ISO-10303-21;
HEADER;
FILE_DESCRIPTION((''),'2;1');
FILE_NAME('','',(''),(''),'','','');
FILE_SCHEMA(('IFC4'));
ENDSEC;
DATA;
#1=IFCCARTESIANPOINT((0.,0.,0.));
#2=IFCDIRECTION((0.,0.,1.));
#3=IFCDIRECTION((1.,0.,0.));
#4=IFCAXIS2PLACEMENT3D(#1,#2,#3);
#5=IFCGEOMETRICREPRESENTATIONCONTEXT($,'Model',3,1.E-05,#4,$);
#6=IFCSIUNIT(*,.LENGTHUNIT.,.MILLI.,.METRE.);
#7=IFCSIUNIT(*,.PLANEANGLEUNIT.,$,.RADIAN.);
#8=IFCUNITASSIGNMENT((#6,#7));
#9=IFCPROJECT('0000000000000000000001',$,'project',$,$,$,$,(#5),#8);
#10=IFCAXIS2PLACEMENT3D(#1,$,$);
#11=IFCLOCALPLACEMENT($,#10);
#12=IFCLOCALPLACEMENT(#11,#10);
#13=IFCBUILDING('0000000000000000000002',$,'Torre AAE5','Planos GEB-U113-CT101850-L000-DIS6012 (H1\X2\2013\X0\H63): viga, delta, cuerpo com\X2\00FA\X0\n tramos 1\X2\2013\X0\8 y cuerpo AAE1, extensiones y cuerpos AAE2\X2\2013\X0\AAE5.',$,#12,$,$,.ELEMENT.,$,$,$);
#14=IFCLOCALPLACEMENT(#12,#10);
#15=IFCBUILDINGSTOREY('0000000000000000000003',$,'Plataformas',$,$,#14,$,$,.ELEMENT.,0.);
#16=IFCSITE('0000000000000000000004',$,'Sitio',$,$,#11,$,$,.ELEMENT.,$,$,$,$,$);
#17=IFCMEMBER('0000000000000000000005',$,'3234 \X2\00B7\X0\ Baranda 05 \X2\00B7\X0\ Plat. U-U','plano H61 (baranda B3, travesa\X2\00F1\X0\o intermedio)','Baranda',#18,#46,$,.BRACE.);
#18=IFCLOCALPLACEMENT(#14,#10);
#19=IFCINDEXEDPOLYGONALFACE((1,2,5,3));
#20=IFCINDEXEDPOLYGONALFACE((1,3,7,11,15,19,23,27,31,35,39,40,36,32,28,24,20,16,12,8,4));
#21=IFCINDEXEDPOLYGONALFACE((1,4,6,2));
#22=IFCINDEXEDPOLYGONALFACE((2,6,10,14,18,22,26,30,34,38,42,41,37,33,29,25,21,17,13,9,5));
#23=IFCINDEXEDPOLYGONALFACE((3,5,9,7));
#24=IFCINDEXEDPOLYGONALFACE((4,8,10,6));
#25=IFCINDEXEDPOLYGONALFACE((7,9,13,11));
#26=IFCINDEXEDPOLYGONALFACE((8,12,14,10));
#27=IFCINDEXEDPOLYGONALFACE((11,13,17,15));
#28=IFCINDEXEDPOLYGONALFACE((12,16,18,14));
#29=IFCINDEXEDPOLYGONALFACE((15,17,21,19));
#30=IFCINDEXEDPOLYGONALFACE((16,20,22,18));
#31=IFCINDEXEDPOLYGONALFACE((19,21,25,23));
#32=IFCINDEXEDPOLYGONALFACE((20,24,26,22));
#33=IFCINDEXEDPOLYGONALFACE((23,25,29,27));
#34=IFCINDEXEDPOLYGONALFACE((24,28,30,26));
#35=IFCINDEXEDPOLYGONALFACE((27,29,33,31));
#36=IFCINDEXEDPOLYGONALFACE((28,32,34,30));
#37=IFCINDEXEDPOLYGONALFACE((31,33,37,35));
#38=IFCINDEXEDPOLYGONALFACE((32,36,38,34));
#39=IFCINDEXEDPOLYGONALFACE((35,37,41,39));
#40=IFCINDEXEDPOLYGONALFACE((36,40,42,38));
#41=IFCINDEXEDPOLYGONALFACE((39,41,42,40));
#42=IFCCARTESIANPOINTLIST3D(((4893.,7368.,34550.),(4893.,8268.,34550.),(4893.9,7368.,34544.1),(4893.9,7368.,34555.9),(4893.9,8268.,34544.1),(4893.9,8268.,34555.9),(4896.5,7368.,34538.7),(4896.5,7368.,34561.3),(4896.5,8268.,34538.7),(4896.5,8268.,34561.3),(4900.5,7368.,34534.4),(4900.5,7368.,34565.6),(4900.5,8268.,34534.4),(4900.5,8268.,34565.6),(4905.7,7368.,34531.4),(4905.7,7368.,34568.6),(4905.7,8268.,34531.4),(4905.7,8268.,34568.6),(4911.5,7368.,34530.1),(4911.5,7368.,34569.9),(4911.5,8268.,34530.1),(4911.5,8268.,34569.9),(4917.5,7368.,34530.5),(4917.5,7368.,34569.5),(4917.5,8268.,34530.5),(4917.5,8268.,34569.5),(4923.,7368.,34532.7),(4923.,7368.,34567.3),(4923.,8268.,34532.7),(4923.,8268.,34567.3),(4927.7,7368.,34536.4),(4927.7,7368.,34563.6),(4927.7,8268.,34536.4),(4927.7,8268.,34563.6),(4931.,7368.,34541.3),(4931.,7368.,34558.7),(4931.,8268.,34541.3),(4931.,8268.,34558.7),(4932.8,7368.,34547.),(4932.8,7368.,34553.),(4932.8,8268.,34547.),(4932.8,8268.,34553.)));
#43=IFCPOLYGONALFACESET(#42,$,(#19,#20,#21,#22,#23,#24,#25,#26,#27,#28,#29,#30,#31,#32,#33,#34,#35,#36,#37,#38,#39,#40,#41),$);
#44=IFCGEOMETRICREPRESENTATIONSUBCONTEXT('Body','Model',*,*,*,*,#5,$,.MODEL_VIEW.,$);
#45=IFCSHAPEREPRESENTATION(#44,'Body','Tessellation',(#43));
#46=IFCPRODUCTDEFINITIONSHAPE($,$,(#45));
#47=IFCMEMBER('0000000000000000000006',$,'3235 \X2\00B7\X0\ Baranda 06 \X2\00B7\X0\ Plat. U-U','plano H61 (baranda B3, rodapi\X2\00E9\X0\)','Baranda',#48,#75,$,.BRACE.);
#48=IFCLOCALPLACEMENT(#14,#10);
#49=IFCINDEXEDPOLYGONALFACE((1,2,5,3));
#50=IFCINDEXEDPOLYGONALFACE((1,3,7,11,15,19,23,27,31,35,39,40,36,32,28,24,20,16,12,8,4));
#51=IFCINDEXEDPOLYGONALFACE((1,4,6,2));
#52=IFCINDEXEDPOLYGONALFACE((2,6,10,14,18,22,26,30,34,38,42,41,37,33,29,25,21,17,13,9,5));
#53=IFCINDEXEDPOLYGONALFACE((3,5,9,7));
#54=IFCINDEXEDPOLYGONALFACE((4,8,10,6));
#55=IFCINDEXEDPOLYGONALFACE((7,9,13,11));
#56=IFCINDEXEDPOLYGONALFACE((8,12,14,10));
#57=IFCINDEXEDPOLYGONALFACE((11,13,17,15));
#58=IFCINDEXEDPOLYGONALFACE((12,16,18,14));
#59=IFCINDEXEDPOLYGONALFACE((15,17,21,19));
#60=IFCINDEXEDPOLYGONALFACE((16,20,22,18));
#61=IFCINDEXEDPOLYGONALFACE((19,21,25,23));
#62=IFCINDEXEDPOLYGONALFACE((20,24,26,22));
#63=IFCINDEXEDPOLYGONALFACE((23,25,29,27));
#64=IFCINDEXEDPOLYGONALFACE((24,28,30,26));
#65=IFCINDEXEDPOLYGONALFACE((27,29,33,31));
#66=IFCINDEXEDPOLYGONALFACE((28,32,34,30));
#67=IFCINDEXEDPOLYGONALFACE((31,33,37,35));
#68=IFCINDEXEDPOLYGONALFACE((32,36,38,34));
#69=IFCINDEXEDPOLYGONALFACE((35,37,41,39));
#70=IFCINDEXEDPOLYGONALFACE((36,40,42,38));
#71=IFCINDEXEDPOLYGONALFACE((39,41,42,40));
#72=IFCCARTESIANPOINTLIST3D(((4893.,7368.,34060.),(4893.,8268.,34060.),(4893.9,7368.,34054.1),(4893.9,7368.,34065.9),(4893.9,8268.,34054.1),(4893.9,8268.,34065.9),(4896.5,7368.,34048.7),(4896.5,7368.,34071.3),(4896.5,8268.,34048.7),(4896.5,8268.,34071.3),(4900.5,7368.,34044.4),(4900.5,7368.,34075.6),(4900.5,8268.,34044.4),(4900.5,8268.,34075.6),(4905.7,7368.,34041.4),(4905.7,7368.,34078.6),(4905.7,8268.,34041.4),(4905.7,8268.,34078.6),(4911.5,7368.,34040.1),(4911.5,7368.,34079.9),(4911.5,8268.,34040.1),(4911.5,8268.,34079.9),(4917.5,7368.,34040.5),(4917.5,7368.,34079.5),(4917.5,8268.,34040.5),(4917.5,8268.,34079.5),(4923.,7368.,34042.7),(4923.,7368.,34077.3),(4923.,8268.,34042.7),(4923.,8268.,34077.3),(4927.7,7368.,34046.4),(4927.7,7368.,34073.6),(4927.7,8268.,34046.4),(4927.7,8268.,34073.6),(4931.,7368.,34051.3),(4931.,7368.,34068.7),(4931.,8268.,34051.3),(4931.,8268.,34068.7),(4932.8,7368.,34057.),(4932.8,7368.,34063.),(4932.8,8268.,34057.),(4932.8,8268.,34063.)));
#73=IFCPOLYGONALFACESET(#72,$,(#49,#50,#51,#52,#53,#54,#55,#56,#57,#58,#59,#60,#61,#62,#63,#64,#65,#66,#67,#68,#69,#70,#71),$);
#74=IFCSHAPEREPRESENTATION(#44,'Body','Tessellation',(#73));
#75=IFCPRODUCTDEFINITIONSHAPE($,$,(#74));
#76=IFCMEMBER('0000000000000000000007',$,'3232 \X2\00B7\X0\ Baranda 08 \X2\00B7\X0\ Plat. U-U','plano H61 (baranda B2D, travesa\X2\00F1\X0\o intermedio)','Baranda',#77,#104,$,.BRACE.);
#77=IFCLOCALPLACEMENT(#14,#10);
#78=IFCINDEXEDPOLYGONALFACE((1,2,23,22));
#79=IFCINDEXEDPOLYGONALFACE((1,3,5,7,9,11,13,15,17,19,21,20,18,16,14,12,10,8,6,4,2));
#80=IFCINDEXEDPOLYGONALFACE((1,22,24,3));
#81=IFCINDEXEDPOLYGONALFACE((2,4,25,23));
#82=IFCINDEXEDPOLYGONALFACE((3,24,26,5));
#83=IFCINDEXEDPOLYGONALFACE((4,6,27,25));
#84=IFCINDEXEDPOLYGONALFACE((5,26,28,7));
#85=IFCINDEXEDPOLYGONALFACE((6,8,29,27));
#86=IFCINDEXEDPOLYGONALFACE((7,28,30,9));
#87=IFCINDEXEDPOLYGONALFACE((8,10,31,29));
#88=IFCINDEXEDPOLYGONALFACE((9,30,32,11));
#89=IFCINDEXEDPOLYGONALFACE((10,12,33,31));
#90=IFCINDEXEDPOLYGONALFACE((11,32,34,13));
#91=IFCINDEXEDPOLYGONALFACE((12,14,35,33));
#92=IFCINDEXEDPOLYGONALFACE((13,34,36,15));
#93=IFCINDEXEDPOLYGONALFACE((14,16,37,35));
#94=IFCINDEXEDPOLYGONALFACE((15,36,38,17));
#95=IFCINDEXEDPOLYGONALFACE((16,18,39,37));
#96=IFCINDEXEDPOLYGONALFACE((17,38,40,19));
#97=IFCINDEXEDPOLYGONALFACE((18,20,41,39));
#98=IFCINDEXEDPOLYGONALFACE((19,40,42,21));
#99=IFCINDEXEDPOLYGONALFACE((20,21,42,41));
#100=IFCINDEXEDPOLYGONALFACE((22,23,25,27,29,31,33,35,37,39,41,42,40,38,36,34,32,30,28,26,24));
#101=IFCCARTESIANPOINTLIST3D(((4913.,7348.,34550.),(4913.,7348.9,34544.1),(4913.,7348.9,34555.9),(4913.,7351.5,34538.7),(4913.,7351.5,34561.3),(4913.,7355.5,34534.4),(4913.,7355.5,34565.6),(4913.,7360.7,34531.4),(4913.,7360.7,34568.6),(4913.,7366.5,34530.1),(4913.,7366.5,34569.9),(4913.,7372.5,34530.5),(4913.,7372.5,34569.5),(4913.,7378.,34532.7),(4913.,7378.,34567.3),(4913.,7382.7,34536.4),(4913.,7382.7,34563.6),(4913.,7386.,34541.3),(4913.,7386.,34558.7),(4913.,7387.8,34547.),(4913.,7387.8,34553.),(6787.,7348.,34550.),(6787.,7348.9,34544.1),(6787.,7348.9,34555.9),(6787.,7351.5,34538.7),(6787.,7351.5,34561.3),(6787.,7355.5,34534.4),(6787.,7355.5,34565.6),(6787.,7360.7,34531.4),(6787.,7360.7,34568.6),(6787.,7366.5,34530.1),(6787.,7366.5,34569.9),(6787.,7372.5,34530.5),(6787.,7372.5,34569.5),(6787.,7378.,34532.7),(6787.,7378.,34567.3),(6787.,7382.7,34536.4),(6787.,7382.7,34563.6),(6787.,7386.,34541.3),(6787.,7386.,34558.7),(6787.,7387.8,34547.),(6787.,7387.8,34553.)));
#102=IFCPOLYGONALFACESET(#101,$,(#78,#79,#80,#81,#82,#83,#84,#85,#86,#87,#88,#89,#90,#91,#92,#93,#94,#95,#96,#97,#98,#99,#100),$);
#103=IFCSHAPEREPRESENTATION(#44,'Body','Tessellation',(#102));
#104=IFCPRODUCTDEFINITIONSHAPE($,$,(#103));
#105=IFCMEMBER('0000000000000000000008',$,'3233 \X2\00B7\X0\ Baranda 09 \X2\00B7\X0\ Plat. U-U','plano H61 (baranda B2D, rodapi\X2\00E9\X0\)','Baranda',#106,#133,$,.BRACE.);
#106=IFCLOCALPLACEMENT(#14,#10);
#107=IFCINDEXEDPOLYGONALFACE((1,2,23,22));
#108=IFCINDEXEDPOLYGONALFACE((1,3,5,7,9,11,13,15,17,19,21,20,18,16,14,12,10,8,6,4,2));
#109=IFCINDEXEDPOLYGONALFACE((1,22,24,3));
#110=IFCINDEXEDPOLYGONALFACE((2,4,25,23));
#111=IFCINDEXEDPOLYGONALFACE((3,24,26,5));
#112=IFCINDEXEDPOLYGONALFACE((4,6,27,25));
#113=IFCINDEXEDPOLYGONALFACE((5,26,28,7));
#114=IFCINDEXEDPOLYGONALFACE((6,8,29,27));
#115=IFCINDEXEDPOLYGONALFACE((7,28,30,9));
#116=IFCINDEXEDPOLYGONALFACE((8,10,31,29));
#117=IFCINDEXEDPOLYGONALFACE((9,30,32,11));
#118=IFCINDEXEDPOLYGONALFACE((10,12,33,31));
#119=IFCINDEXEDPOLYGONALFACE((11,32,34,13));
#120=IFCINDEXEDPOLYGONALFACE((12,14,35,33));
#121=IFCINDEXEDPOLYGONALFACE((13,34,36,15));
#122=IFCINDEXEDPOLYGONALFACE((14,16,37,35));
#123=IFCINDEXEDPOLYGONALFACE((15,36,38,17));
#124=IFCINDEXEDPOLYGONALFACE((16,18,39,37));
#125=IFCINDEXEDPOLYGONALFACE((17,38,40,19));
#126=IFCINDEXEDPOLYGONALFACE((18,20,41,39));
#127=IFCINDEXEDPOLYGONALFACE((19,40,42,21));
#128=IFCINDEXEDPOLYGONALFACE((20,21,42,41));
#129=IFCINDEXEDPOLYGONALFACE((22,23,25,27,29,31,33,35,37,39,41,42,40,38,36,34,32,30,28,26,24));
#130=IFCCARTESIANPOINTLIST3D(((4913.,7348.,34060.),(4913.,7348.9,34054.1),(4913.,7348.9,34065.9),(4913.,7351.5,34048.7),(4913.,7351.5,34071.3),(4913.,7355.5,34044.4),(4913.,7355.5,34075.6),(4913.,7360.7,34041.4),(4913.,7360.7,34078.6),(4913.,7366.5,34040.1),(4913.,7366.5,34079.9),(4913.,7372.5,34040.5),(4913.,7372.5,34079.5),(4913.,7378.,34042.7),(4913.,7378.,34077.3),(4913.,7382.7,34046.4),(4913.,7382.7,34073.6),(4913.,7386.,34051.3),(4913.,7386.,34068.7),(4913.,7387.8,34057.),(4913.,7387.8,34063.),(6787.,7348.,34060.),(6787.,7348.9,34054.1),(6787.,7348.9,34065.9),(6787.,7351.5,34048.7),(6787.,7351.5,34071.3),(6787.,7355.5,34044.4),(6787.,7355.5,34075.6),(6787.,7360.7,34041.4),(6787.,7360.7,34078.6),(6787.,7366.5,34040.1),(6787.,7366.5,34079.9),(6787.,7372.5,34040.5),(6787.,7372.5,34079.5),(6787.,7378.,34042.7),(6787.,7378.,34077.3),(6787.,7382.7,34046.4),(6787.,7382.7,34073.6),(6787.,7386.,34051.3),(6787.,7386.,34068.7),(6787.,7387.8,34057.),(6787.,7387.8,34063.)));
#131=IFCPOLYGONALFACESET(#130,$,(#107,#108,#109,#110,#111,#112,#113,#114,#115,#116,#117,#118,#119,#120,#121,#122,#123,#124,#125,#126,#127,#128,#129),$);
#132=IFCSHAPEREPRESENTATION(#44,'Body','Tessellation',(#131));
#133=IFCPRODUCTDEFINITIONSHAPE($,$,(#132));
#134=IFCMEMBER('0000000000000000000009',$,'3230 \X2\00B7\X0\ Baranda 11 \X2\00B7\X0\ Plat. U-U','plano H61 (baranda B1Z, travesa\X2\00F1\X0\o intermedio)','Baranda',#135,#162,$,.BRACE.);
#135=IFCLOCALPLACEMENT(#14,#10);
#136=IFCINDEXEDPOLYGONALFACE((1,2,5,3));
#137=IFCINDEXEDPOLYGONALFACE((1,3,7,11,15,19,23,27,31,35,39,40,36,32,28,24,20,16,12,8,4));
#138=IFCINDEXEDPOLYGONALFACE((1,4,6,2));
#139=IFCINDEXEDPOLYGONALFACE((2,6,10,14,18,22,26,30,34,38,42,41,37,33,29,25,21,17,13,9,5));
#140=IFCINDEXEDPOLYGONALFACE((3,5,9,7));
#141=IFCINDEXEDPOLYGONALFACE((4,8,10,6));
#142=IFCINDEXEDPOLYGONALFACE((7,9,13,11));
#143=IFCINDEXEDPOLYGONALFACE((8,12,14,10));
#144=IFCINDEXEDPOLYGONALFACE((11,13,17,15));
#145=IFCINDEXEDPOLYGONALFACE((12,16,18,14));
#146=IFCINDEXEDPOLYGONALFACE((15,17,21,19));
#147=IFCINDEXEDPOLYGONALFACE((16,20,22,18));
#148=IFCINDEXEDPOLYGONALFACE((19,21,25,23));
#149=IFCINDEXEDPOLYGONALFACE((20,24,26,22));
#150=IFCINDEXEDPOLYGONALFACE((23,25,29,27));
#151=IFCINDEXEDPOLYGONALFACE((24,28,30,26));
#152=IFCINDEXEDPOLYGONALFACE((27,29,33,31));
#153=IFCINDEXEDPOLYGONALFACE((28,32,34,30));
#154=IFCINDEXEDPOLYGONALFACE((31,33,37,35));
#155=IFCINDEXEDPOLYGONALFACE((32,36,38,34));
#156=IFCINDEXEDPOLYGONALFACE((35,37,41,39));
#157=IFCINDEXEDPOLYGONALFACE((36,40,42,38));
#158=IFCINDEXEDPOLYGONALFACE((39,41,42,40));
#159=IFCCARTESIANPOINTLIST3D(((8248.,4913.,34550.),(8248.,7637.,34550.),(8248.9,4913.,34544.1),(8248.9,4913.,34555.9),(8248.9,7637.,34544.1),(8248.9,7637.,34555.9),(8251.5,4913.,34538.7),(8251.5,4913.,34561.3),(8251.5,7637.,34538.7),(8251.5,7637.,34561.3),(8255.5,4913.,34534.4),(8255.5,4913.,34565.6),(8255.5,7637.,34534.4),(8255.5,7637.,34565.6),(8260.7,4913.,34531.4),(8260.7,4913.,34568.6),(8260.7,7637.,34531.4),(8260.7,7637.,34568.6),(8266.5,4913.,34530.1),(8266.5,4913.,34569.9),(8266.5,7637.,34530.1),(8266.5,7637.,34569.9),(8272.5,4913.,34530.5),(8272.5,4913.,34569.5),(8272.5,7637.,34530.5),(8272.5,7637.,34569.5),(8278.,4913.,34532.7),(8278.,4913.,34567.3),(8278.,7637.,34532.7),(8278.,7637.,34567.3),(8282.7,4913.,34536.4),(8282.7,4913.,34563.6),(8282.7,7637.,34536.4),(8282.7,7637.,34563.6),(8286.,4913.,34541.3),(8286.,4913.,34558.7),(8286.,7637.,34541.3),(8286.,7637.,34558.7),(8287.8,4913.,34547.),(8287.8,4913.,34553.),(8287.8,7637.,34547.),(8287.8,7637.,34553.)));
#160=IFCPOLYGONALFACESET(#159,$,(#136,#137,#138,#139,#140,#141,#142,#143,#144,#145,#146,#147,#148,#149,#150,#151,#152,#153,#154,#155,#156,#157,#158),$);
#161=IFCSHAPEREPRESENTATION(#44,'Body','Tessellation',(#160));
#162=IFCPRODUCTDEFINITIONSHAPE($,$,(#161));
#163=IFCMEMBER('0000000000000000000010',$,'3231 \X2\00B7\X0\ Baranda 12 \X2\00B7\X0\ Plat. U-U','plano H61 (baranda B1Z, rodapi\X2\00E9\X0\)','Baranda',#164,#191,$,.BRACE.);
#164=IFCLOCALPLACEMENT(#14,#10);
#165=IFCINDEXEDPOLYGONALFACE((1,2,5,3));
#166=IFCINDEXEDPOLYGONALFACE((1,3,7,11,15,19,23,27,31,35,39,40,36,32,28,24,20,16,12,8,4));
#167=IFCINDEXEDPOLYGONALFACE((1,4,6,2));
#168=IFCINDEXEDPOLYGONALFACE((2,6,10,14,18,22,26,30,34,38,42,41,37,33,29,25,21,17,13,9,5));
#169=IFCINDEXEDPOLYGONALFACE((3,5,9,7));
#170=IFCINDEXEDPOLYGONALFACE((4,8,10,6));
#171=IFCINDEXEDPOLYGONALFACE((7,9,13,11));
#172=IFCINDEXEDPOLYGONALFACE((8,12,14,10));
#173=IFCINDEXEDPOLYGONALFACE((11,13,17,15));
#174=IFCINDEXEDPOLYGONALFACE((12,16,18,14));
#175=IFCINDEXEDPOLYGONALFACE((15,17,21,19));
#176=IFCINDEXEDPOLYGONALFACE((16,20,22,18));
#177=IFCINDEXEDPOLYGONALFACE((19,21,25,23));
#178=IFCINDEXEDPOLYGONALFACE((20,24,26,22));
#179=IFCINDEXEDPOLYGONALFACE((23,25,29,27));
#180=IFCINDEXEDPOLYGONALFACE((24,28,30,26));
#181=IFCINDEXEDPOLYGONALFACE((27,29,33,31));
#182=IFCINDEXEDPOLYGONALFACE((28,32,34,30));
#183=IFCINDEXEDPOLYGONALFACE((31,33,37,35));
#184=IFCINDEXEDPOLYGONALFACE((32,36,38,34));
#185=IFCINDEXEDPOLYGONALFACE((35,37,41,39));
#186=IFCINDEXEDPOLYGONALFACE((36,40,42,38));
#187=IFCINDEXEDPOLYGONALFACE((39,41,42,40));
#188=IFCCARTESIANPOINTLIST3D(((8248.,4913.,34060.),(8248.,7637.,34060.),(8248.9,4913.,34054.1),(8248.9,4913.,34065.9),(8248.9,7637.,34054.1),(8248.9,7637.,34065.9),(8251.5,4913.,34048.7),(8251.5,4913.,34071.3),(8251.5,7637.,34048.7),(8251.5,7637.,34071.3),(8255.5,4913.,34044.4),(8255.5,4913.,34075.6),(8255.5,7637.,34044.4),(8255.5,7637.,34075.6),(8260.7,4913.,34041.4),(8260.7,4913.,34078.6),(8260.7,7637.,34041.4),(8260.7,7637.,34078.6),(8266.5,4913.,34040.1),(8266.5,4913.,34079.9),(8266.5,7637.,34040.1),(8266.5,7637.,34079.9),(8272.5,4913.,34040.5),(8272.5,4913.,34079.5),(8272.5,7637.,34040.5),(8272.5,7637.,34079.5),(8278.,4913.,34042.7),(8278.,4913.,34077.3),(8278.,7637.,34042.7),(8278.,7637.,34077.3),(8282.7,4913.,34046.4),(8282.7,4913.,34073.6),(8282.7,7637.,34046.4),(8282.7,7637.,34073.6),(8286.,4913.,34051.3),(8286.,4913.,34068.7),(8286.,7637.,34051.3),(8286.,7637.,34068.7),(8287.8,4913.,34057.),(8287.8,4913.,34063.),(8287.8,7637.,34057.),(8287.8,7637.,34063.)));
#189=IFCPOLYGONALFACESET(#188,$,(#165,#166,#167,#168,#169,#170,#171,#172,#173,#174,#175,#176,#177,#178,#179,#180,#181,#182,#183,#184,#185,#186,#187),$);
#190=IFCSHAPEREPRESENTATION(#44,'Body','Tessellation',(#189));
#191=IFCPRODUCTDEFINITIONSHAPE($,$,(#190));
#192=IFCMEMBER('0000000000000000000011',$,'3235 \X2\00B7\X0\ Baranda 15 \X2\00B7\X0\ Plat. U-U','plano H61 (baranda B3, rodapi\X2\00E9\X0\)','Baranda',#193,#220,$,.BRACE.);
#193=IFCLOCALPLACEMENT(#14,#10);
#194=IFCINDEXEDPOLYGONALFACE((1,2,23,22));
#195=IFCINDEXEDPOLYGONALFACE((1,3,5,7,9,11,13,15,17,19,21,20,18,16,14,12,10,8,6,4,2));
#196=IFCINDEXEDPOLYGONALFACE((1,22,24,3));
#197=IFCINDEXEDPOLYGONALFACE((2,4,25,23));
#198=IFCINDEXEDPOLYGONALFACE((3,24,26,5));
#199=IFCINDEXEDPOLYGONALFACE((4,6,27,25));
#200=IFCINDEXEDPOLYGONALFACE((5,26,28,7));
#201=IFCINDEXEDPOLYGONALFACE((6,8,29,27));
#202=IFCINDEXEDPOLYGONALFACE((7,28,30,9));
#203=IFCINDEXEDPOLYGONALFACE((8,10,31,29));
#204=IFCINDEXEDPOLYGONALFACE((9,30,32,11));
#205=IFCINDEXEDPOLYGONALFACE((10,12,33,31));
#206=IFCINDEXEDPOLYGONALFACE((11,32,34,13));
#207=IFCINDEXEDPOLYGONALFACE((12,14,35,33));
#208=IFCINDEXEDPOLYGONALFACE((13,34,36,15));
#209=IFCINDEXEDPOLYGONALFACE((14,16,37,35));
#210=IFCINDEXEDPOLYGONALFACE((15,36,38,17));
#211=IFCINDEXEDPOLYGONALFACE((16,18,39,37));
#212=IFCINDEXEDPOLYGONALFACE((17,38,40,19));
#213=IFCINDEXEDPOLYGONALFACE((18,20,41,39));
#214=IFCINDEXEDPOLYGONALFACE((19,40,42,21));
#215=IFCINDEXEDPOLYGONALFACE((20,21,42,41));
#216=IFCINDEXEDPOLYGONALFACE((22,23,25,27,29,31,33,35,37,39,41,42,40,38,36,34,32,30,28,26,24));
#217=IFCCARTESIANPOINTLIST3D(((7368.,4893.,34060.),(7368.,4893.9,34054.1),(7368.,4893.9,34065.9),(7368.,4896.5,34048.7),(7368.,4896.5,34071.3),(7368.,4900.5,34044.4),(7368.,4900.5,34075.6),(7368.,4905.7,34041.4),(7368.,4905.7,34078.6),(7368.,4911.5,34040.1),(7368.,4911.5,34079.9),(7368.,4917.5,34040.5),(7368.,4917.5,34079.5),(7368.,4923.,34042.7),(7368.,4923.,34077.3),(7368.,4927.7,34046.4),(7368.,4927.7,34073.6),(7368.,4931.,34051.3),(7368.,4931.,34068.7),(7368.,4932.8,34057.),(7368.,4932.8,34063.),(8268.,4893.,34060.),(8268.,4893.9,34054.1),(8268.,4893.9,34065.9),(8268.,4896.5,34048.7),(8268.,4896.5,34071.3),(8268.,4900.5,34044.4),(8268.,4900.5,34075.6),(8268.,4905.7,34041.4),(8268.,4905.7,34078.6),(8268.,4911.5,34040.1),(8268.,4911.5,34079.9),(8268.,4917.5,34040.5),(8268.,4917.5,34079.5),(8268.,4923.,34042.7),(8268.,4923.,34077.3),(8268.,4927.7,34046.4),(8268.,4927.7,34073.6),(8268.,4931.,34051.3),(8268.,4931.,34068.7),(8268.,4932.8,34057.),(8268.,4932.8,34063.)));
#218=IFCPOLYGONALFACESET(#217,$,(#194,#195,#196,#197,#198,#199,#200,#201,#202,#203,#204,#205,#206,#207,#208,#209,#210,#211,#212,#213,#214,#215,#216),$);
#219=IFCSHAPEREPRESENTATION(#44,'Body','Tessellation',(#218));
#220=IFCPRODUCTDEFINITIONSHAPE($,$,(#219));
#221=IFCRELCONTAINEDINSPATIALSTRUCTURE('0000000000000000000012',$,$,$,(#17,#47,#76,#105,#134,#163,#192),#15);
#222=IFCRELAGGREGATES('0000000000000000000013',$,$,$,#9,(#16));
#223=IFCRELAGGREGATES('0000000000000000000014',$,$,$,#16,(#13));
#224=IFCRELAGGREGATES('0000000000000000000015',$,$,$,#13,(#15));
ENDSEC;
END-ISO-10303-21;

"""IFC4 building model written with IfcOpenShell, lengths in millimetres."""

from ifc_helpers import new_model, si_unit, frame, origin, origin_with_axes, place, context, subcontext, project, spatial, circle, extrude, element, save


model = new_model("IFC4")

# Units and contexts
model_context = context("Model", 3, precision=1e-05, world=origin_with_axes())
body_context = subcontext(model_context, "Body", "Model", "MODEL_VIEW")
ifc_project = project(units=[si_unit("LENGTHUNIT", "METRE", prefix="MILLI"), si_unit("PLANEANGLEUNIT", "RADIAN")], contexts=[model_context])

# Site, building, storey
site_placement = place(None, origin())
site = spatial("IfcSite", under=ifc_project, at=site_placement, Name="Sitio", CompositionType="ELEMENT")
building_placement = place(site_placement, origin())
building = spatial("IfcBuilding", under=site, at=building_placement, Name="Torre AAE5", Description="Planos GEB-U113-CT101850-L000-DIS6012 (H1–H63): viga, delta, cuerpo común tramos 1–8 y cuerpo AAE1, extensiones y cuerpos AAE2–AAE5.", CompositionType="ELEMENT")
storey_placement = place(building_placement, origin())
storey = spatial("IfcBuildingStorey", under=building, at=storey_placement, Name="Plataformas", CompositionType="ELEMENT", Elevation=0.0)

# Members
for number, where, z_axis, x_axis, name, description in (
    (1, (4913.0, 8268.0, 34550.0), (0.0, -1.0, 0.0), (-1.0, 0.0, 0.0), "3234 · Baranda 05 · Plat. U-U", "plano H61 (baranda B3, travesaño intermedio)"),
    (2, (4913.0, 8268.0, 34060.0), (0.0, -1.0, 0.0), (-1.0, 0.0, 0.0), "3235 · Baranda 06 · Plat. U-U", "plano H61 (baranda B3, rodapié)"),
):
    element("IfcMember", number, at=place(storey_placement, frame(where, z_axis=z_axis, x_axis=x_axis)), inside=storey, Name=name, Description=description, ObjectType="Baranda", PredefinedType="BRACE", context=body_context, shape_type="SweptSolid", body=[
        extrude(circle(Radius=20.0), None, (0.0, 0.0, 1.0), 900.0),
    ])
for number, where, z_axis, x_axis, name, description in (
    (3, (4913.0, 7368.0, 34550.0), (1.0, 0.0, 0.0), (0.0, -1.0, 0.0), "3232 · Baranda 08 · Plat. U-U", "plano H61 (baranda B2D, travesaño intermedio)"),
    (4, (4913.0, 7368.0, 34060.0), (1.0, 0.0, 0.0), (0.0, -1.0, 0.0), "3233 · Baranda 09 · Plat. U-U", "plano H61 (baranda B2D, rodapié)"),
):
    element("IfcMember", number, at=place(storey_placement, frame(where, z_axis=z_axis, x_axis=x_axis)), inside=storey, Name=name, Description=description, ObjectType="Baranda", PredefinedType="BRACE", context=body_context, shape_type="SweptSolid", body=[
        extrude(circle(Radius=20.0), None, (0.0, 0.0, 1.0), 1874.0),
    ])
for number, where, z_axis, x_axis, name, description in (
    (5, (8268.0, 7637.0, 34550.0), (0.0, -1.0, 0.0), (-1.0, 0.0, 0.0), "3230 · Baranda 11 · Plat. U-U", "plano H61 (baranda B1Z, travesaño intermedio)"),
    (6, (8268.0, 7637.0, 34060.0), (0.0, -1.0, 0.0), (-1.0, 0.0, 0.0), "3231 · Baranda 12 · Plat. U-U", "plano H61 (baranda B1Z, rodapié)"),
):
    element("IfcMember", number, at=place(storey_placement, frame(where, z_axis=z_axis, x_axis=x_axis)), inside=storey, Name=name, Description=description, ObjectType="Baranda", PredefinedType="BRACE", context=body_context, shape_type="SweptSolid", body=[
        extrude(circle(Radius=20.0), None, (0.0, 0.0, 1.0), 2724.0),
    ])
member_1_placement = place(storey_placement, frame((8268.0, 4913.0, 34060.0), z_axis=(-1.0, 0.0, 0.0), x_axis=(0.0, -1.0, 0.0)))
element("IfcMember", 7, at=member_1_placement, inside=storey, Name="3235 · Baranda 15 · Plat. U-U", Description="plano H61 (baranda B3, rodapié)", ObjectType="Baranda", PredefinedType="BRACE", context=body_context, shape_type="SweptSolid", body=[
    extrude(circle(Radius=20.0), None, (0.0, 0.0, 1.0), 900.0),
])

save(model, "model.ifc")
